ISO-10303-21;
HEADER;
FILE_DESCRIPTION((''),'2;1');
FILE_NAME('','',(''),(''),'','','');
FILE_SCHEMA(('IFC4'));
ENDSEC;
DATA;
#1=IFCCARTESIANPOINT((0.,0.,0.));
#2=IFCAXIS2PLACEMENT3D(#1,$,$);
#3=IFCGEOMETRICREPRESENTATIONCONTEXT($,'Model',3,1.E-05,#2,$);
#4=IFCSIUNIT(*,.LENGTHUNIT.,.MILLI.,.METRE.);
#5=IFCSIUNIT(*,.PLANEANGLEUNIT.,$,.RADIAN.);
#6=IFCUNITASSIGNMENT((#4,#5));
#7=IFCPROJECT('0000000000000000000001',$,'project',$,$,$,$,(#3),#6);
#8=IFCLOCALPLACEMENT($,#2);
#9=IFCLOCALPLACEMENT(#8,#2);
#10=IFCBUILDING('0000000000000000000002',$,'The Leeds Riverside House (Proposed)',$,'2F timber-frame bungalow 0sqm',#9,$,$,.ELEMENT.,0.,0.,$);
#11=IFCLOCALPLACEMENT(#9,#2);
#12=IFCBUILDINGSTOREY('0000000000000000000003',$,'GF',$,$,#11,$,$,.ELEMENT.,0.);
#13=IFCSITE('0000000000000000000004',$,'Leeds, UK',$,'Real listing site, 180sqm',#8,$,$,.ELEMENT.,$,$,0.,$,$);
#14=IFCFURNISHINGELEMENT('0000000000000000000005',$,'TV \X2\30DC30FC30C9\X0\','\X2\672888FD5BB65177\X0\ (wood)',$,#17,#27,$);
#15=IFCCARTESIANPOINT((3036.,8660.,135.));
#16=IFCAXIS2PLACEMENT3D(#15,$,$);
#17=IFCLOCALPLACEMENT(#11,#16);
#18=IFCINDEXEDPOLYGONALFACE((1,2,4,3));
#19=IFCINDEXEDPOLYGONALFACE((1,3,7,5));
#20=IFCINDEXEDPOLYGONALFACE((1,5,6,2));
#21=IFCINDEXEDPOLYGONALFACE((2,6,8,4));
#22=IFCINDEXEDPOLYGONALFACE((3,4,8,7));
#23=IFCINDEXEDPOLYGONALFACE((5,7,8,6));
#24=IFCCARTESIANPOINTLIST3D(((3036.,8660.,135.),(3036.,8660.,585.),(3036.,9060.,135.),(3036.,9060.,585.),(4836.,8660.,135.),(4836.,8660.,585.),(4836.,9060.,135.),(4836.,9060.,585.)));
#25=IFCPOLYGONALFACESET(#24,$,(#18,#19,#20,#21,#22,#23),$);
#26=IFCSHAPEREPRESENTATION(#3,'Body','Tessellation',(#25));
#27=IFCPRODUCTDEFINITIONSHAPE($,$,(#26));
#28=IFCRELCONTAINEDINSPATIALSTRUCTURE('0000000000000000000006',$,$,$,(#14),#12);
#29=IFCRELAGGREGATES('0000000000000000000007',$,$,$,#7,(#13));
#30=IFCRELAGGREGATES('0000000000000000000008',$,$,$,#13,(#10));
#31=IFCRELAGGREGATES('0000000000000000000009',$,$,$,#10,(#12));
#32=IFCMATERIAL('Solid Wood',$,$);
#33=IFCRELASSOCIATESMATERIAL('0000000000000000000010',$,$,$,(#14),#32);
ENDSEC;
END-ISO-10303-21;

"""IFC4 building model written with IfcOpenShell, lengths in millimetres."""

from ifc_helpers import new_model, si_unit, frame, frame_2d, origin, place, context, project, spatial, rectangle, extrude, material, element, save


model = new_model("IFC4")

# Units and contexts
model_context = context("Model", 3, precision=1e-05, world=origin())
ifc_project = project(units=[si_unit("LENGTHUNIT", "METRE", prefix="MILLI"), si_unit("PLANEANGLEUNIT", "RADIAN")], contexts=[model_context])

# Site, building, storey
site_placement = place(None, origin())
site = spatial("IfcSite", under=ifc_project, at=site_placement, Name="Leeds, UK", ObjectType="Real listing site, 180sqm", CompositionType="ELEMENT", RefElevation=0.0)
building_placement = place(site_placement, origin())
building = spatial("IfcBuilding", under=site, at=building_placement, Name="The Leeds Riverside House (Proposed)", ObjectType="2F timber-frame bungalow 0sqm", CompositionType="ELEMENT", ElevationOfRefHeight=0.0, ElevationOfTerrain=0.0)
storey_placement = place(building_placement, origin())
storey = spatial("IfcBuildingStorey", under=building, at=storey_placement, Name="GF", CompositionType="ELEMENT", Elevation=0.0)

# Shared definitions
ifc_material_1 = material(Name="Solid Wood")

# Furnishing element
furnishing_placement = place(storey_placement, frame((3036.0, 8660.0, 135.0)))
element("IfcFurnishingElement", 1, at=furnishing_placement, inside=storey, material=ifc_material_1, Name="TV ボード", Description="木製家具 (wood)", context=model_context, shape_type="SweptSolid", body=[
    extrude(rectangle(XDim=1800.0, YDim=400.0, at=frame_2d((900.0, 200.0))), frame((3036.0, 8660.0, 135.0)), (0.0, 0.0, 1.0), 450.0),
])

save(model, "model.ifc")
